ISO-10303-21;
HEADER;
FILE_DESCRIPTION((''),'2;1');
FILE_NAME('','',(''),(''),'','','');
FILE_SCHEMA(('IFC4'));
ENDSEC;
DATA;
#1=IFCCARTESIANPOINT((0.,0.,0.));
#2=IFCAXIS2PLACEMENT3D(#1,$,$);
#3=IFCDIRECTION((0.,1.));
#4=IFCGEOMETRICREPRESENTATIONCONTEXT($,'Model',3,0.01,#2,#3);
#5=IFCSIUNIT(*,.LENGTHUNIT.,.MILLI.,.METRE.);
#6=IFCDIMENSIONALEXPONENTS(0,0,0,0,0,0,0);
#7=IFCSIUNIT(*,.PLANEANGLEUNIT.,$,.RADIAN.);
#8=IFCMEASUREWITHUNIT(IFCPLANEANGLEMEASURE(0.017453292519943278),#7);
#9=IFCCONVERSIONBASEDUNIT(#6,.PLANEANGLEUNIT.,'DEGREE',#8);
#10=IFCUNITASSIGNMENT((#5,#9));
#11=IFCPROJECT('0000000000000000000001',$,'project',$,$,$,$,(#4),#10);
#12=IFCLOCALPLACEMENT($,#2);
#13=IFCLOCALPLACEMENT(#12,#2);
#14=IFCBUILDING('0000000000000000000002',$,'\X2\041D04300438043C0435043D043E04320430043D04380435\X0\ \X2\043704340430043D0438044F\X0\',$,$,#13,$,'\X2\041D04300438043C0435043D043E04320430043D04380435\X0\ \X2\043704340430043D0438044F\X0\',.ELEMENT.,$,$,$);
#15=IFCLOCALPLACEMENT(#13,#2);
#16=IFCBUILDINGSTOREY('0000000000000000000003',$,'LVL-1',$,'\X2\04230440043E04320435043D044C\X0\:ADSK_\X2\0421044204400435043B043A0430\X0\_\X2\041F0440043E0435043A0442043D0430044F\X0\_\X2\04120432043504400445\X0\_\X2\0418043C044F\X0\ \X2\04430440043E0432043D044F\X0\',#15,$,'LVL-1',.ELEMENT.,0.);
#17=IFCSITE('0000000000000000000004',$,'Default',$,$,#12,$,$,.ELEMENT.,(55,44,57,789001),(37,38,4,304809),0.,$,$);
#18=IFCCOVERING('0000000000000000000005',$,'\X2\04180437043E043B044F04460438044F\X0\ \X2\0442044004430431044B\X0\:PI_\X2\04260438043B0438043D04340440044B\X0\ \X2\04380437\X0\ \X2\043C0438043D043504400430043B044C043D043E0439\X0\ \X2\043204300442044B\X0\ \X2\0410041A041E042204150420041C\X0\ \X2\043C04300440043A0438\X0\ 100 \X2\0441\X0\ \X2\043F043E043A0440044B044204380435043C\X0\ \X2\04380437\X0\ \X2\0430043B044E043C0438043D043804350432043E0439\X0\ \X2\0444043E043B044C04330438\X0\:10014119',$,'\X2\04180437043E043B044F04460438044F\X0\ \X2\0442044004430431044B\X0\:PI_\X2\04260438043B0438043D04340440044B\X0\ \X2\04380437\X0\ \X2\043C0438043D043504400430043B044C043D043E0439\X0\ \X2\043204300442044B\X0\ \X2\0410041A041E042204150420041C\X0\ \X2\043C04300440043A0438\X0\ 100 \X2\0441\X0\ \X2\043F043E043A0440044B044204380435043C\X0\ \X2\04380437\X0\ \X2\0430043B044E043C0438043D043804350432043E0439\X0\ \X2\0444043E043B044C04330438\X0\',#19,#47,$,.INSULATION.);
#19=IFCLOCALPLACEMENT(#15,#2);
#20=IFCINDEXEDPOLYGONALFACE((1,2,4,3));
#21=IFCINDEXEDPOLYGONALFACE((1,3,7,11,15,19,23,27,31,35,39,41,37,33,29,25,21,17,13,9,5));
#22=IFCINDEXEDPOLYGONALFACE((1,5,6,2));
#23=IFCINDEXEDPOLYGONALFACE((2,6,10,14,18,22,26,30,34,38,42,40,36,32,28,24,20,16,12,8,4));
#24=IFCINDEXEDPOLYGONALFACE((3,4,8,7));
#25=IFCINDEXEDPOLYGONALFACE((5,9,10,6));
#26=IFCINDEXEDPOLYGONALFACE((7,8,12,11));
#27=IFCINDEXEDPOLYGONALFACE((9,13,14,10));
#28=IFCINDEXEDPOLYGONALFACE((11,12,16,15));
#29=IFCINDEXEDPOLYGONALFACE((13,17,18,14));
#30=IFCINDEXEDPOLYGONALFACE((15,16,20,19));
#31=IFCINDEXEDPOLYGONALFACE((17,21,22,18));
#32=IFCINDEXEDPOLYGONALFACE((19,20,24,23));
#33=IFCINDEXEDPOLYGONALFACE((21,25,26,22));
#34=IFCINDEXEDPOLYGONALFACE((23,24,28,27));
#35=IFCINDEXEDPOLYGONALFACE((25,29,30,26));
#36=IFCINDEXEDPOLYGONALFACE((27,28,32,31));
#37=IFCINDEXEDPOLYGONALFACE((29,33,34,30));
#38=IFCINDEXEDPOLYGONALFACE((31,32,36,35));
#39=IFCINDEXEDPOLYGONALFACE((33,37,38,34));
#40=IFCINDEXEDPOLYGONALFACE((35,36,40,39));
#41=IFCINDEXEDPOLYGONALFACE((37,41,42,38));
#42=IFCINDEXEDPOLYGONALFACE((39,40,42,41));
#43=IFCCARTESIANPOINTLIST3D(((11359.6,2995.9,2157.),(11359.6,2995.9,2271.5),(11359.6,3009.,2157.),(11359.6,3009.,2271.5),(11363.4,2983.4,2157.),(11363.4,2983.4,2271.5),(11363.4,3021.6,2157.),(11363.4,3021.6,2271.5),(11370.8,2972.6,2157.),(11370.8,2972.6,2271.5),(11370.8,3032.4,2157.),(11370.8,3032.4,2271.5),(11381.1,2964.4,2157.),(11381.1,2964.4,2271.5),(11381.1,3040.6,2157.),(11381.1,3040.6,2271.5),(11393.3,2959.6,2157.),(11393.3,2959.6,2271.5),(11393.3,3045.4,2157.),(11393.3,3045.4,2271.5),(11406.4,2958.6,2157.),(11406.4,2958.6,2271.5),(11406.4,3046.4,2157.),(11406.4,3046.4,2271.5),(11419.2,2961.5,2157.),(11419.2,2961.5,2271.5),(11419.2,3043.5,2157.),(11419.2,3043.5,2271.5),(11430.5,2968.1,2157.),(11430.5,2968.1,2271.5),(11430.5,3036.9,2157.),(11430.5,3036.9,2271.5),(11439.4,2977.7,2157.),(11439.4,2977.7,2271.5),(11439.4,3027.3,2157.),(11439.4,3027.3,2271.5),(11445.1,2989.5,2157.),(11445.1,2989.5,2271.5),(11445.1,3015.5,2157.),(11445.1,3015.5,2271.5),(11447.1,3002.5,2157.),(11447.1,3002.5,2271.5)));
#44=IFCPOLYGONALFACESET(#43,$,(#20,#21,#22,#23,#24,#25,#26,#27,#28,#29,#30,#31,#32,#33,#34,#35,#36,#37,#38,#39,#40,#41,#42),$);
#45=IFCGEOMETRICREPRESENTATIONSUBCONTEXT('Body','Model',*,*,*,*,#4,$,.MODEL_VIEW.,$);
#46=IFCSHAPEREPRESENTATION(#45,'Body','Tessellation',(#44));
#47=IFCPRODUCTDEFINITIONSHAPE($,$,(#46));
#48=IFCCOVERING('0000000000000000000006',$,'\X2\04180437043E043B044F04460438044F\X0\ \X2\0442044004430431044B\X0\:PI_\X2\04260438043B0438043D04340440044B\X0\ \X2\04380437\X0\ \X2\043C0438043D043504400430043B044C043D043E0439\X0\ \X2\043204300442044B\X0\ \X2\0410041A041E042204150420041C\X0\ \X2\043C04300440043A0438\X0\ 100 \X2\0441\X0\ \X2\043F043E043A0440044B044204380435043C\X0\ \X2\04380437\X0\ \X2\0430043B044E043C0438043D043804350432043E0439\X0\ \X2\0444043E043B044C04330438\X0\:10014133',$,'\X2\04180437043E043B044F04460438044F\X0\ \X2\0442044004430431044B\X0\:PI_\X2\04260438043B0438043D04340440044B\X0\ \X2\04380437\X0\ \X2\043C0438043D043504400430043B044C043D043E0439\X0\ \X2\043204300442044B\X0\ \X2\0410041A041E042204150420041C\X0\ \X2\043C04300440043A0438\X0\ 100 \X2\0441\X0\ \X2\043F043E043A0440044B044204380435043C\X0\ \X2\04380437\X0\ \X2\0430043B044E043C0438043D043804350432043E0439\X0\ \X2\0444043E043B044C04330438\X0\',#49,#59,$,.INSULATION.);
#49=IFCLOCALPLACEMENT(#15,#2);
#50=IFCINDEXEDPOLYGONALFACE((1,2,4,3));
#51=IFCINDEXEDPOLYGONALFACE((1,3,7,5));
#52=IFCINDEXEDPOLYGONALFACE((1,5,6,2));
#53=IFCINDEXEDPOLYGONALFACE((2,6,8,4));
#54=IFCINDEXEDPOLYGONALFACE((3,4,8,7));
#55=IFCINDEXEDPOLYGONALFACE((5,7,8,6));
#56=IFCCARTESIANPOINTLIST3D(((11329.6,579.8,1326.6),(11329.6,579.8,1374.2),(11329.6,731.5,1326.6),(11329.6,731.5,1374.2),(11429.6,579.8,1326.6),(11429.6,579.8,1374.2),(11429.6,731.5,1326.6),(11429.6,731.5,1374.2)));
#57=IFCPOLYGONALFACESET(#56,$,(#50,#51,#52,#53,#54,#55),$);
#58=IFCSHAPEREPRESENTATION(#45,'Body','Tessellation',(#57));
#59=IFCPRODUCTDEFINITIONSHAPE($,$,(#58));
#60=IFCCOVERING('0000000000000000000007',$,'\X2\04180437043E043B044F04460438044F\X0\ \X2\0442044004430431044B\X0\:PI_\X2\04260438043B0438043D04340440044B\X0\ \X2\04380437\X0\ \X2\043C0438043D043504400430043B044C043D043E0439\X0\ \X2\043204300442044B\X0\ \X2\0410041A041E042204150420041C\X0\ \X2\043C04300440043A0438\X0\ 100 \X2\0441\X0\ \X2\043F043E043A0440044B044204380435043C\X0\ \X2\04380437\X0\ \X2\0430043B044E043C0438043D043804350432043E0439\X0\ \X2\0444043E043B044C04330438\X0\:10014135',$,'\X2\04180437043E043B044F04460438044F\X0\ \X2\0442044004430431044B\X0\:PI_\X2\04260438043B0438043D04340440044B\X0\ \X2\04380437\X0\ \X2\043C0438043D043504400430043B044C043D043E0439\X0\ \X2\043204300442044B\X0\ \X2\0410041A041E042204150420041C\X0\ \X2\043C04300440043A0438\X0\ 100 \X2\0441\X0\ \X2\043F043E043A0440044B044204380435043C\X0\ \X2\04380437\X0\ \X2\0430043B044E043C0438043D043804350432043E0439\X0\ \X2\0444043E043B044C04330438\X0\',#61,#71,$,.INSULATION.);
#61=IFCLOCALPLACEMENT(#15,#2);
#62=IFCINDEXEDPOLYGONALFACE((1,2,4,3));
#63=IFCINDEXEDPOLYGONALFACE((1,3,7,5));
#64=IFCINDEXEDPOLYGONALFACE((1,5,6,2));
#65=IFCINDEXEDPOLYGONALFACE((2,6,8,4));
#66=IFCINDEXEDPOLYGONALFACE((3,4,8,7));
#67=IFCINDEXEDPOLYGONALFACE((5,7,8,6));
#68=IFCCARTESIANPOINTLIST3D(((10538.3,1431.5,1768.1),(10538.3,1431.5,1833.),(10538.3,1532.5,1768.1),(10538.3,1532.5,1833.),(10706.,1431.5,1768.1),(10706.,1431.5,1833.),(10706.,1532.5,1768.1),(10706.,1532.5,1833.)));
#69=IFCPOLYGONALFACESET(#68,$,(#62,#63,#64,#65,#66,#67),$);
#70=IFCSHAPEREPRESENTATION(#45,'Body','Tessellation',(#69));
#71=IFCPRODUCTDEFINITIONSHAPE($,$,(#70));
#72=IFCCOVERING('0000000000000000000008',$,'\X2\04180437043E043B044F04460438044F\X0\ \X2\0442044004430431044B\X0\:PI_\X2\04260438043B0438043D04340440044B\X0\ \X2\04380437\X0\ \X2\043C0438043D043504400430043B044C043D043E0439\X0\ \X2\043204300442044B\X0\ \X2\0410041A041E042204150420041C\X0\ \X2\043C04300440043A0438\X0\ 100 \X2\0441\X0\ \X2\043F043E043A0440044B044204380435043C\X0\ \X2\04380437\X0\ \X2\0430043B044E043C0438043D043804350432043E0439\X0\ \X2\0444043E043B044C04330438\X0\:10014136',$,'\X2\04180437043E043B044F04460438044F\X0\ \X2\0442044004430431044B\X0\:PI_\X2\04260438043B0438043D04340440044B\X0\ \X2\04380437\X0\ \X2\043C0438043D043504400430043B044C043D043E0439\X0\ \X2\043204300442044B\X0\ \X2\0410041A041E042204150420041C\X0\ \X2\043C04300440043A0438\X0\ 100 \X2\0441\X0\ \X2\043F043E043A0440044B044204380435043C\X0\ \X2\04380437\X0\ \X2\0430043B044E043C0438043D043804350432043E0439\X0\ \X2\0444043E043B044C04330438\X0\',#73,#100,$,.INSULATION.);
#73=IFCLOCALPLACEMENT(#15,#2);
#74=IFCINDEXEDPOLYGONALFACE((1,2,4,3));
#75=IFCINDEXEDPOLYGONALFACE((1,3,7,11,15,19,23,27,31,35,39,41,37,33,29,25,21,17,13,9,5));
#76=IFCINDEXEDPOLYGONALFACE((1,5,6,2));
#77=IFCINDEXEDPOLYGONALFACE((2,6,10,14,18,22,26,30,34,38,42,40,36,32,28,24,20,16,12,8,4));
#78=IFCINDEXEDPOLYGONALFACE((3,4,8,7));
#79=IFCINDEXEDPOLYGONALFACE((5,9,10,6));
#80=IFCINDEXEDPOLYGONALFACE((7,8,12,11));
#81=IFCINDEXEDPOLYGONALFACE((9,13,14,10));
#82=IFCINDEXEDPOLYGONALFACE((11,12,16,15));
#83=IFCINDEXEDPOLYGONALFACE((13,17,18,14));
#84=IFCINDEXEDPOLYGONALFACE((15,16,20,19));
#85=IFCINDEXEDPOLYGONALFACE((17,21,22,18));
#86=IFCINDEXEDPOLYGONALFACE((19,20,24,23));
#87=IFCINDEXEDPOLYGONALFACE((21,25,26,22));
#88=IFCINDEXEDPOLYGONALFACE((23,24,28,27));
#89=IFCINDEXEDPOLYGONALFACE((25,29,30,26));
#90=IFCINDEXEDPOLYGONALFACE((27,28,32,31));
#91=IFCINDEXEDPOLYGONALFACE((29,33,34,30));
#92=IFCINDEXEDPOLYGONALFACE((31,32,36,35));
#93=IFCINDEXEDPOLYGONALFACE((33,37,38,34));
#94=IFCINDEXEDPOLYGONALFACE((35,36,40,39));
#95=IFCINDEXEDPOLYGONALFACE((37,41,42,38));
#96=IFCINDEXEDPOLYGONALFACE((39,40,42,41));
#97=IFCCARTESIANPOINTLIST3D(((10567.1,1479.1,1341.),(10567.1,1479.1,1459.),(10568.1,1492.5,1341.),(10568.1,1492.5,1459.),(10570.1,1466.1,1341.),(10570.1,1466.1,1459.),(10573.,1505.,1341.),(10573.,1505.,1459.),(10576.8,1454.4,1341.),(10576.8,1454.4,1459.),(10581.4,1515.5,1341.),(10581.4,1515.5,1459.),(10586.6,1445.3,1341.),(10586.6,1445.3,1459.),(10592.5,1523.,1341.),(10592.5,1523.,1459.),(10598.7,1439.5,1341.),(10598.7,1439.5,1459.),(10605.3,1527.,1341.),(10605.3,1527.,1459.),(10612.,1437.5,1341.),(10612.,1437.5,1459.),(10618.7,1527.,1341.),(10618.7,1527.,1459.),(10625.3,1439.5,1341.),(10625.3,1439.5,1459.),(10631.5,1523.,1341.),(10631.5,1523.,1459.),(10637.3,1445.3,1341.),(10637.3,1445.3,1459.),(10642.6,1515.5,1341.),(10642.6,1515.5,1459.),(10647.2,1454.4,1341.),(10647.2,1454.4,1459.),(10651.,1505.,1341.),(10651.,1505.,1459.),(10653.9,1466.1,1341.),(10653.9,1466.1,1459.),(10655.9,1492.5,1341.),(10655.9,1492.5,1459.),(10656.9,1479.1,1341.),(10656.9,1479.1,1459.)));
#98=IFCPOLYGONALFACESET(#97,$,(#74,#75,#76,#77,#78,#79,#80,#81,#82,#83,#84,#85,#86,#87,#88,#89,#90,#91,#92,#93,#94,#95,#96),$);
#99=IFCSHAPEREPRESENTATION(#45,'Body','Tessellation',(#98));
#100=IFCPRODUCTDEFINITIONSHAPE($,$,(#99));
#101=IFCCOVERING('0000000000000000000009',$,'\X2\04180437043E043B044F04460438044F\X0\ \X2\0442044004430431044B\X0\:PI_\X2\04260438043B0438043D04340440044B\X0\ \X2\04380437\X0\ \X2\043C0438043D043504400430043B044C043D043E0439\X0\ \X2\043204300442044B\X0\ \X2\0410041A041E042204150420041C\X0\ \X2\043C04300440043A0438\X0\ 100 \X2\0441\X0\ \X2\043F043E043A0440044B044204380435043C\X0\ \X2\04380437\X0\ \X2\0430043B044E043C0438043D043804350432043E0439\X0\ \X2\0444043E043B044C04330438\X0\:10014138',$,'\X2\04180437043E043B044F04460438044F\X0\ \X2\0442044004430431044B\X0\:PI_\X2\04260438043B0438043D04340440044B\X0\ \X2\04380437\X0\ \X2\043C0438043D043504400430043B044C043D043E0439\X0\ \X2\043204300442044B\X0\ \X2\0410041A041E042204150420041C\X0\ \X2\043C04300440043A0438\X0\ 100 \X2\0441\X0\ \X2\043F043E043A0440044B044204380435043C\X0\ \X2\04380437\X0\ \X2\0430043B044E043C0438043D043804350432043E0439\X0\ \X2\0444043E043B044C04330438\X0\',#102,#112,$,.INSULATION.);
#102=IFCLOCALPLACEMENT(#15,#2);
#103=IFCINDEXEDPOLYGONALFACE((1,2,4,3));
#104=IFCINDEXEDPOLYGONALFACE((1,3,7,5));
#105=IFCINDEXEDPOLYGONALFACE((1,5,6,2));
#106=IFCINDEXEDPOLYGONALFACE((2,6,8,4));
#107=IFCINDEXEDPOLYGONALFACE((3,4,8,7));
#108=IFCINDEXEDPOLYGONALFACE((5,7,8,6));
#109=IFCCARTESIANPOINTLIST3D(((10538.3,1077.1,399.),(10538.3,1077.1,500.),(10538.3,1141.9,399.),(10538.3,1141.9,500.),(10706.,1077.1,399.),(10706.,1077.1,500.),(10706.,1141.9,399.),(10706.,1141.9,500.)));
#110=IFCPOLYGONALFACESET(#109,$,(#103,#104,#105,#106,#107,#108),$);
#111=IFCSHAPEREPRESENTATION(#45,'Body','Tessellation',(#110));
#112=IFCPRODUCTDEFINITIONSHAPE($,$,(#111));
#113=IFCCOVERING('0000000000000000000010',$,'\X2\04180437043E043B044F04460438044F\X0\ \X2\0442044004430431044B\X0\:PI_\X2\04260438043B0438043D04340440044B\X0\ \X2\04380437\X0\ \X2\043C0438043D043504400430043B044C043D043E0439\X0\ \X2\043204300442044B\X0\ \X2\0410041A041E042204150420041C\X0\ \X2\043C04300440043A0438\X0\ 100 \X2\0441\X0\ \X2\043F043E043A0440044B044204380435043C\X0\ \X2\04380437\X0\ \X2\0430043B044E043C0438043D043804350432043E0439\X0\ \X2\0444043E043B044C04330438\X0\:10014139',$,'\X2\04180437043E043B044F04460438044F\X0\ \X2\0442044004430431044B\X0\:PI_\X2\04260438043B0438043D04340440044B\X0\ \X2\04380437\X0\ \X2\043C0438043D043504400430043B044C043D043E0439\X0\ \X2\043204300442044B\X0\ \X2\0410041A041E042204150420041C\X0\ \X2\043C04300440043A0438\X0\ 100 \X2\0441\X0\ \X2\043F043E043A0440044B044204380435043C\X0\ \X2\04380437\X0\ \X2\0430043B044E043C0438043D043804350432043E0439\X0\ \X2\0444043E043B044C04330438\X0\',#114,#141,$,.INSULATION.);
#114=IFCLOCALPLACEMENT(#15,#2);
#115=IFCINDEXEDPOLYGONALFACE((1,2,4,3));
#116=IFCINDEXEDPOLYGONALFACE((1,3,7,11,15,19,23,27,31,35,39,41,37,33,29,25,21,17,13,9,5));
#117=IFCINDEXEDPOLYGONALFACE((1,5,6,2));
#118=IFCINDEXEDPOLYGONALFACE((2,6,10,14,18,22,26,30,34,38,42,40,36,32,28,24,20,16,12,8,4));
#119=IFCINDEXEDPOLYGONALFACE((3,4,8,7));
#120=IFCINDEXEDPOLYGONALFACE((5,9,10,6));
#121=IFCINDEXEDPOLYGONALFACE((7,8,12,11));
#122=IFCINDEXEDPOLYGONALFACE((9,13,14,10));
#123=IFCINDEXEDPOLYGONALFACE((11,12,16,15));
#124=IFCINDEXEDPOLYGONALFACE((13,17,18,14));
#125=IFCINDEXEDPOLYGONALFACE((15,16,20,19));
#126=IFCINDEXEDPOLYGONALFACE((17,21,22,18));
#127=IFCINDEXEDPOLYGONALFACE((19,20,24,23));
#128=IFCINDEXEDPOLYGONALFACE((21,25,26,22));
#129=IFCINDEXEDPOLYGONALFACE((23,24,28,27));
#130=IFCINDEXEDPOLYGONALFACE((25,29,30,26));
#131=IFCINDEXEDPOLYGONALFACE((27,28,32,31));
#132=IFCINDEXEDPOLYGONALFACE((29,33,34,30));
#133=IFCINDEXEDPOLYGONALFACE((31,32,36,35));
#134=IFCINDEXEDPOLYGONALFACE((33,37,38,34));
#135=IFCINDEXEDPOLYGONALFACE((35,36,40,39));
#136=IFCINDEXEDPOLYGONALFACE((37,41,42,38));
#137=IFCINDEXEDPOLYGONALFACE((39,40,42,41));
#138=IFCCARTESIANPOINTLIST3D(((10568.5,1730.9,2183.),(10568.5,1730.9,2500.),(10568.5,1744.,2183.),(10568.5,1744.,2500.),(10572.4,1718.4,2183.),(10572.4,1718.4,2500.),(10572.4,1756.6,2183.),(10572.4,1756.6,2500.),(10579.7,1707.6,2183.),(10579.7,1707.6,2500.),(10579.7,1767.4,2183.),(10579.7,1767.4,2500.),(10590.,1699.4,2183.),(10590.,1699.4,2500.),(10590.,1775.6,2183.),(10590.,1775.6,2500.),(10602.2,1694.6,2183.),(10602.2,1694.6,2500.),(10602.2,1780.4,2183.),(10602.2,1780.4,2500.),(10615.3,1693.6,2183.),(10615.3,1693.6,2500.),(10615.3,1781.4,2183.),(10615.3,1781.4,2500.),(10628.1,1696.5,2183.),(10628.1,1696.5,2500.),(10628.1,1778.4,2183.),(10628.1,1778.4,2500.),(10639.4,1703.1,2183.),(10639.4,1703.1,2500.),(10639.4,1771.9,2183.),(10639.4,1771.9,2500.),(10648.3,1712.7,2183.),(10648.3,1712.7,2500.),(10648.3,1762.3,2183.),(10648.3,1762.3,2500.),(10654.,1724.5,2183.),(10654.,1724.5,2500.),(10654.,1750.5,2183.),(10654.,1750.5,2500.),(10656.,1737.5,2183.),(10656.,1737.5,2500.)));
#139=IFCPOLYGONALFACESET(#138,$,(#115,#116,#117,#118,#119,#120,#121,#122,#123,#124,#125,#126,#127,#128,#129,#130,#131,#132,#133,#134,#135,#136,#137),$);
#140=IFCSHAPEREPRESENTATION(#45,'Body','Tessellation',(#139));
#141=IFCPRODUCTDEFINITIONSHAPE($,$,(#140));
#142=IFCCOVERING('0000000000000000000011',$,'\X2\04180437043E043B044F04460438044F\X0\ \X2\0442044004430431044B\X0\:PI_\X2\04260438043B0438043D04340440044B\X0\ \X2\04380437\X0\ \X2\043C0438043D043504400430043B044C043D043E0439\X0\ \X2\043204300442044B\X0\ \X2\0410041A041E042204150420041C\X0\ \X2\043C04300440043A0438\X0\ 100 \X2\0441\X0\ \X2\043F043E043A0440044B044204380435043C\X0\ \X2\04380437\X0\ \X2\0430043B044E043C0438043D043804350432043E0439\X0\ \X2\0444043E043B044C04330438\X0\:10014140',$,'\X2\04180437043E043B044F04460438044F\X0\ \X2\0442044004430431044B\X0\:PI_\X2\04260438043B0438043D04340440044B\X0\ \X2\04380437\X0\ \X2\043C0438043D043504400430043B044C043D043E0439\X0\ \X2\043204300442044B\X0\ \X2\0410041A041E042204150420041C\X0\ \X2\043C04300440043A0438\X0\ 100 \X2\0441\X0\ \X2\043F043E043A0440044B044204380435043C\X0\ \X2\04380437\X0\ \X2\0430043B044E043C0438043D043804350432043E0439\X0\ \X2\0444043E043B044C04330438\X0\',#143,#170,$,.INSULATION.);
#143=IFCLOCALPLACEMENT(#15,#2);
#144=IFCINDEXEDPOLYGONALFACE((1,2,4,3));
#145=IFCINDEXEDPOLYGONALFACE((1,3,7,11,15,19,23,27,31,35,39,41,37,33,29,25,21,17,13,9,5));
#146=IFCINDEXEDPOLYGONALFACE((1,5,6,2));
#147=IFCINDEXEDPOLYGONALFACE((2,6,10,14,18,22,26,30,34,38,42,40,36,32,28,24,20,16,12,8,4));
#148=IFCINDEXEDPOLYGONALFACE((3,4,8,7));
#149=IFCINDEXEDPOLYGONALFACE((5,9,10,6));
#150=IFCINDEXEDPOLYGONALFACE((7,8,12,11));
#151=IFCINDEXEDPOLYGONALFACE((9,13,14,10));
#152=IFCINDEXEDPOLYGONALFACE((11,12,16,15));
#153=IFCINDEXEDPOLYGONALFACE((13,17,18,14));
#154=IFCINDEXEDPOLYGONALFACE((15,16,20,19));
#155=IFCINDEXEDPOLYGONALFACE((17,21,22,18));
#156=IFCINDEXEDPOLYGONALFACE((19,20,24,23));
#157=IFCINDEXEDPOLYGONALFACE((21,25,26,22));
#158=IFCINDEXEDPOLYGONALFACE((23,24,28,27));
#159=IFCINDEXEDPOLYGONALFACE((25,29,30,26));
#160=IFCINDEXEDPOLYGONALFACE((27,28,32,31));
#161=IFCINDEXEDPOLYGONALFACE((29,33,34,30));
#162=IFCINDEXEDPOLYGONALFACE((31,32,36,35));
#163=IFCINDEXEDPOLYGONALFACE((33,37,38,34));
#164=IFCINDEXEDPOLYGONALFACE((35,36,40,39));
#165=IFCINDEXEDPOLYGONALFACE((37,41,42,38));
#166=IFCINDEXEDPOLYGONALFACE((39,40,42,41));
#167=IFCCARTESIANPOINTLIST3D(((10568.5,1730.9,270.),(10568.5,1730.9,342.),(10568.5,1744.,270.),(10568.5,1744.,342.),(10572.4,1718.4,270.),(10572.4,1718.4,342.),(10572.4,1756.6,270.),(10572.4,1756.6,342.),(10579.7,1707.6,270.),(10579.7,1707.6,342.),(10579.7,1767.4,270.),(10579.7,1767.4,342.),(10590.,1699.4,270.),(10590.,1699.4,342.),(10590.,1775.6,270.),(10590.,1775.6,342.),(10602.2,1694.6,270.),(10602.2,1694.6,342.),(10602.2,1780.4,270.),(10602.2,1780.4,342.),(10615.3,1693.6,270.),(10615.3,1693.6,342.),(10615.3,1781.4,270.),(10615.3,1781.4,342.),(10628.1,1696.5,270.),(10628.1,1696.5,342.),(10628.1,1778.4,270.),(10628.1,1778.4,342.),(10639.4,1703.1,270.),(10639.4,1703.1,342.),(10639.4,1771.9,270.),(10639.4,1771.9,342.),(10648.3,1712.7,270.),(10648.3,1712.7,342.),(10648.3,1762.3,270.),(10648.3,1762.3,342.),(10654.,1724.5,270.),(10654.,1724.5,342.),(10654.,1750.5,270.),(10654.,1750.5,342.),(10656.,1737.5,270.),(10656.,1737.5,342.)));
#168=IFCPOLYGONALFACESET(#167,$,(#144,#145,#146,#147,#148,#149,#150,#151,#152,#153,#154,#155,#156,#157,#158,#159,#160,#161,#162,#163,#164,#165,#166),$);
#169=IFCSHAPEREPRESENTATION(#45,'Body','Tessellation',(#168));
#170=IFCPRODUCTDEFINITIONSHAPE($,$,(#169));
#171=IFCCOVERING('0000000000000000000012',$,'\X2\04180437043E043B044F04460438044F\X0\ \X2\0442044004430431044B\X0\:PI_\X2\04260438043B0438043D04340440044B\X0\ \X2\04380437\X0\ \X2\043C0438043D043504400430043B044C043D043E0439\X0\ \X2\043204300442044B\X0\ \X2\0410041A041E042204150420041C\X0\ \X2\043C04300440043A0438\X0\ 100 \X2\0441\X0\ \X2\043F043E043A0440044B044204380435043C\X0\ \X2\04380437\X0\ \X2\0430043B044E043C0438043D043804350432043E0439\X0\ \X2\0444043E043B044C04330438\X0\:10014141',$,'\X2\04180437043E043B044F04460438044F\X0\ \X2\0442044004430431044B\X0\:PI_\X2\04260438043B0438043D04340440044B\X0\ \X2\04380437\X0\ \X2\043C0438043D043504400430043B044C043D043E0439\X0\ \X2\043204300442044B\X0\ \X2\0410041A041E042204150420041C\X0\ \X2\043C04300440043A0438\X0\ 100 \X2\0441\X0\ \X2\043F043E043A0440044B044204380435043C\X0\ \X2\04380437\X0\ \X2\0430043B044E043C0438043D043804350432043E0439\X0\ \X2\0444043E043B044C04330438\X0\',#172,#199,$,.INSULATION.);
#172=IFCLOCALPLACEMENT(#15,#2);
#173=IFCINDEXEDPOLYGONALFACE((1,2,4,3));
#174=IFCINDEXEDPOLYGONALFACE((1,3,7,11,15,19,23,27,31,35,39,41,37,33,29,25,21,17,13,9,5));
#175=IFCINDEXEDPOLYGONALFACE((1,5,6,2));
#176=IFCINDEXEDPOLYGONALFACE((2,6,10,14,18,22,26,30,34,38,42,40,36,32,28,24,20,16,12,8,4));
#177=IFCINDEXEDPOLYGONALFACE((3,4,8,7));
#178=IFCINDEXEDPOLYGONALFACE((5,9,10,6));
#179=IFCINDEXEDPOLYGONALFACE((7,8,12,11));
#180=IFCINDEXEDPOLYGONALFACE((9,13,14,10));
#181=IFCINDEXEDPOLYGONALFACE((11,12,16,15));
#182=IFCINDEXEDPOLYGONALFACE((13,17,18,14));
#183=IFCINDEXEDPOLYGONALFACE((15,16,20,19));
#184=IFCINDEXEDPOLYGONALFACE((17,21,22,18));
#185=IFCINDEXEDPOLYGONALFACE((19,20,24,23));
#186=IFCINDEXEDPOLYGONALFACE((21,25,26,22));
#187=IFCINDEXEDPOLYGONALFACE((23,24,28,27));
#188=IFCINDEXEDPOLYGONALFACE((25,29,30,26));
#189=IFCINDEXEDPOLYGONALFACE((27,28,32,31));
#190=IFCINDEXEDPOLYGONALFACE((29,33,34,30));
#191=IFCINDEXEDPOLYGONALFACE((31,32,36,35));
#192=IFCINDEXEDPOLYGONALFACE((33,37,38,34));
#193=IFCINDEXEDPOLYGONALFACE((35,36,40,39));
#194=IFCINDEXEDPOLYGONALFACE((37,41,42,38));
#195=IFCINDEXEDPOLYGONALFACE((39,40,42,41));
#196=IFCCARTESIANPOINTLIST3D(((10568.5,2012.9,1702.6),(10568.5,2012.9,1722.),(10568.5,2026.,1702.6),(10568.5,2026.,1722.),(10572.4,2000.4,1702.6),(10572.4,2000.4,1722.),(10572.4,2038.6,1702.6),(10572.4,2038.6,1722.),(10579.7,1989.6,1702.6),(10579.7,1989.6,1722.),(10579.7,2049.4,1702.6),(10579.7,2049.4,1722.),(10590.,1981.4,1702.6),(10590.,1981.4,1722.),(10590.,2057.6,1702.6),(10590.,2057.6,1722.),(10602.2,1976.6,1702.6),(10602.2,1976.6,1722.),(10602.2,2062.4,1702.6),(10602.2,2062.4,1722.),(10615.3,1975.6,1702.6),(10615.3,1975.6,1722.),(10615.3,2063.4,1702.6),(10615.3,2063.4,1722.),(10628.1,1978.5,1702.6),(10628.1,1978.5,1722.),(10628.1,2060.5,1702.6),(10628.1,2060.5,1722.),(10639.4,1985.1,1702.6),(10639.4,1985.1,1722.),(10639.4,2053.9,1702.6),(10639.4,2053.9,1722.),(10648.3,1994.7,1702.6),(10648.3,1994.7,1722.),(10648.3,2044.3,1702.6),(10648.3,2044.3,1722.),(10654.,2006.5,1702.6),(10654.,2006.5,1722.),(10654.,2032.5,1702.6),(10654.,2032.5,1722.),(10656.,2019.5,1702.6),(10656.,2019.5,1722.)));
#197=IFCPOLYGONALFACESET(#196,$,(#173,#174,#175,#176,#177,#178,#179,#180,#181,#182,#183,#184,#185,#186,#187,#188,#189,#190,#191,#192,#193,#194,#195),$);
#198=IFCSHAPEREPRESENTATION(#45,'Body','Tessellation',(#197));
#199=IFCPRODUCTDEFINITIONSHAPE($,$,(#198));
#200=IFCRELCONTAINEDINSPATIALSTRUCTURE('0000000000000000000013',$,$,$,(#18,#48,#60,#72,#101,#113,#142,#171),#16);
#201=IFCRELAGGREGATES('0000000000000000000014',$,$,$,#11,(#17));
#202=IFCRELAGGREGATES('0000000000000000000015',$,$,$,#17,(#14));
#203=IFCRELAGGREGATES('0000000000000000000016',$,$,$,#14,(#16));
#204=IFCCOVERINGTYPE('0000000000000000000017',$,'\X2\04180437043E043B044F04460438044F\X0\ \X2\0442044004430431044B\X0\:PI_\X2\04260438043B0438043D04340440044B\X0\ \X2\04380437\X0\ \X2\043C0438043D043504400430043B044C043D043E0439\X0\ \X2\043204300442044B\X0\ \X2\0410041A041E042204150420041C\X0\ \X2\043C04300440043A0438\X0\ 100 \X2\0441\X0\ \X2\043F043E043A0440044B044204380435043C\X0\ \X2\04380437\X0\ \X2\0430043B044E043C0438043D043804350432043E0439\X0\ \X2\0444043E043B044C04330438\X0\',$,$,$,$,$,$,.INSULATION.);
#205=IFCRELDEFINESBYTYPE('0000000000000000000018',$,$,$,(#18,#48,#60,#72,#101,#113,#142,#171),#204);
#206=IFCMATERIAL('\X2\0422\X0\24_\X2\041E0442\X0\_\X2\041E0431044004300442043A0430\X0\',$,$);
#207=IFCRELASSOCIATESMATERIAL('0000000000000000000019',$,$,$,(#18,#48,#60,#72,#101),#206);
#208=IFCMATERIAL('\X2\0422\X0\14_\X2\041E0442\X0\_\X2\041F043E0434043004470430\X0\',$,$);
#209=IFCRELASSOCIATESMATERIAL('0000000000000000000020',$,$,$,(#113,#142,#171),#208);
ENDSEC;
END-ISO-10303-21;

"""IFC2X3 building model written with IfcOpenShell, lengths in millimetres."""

from ifc_helpers import new_model, entity, si_unit, converted_unit, direction, frame, frame_2d, origin, origin_2d_with_axis, place, context, subcontext, project, spatial, rectangle, circle, extrude, material, type_object, element, save


model = new_model("IFC2X3")

# Units and contexts
model_context = context("Model", 3, precision=0.01, world=origin(), true_north=direction((0.0, 1.0)))
body_context = subcontext(model_context, "Body", "Model", "MODEL_VIEW")
ifc_project = project(units=[si_unit("LENGTHUNIT", "METRE", prefix="MILLI"), converted_unit("PLANEANGLEUNIT", "DEGREE", entity("IfcPlaneAngleMeasure", 0.017453292519943278), si_unit("PLANEANGLEUNIT", "RADIAN"), dimensions=[0, 0, 0, 0, 0, 0, 0])], contexts=[model_context])

# Site, building, storey
site_placement = place(None, origin())
site = spatial("IfcSite", under=ifc_project, at=site_placement, Name="Default", CompositionType="ELEMENT", RefLatitude=(55, 44, 57, 789001), RefLongitude=(37, 38, 4, 304809), RefElevation=0.0)
building_placement = place(site_placement, origin())
building = spatial("IfcBuilding", under=site, at=building_placement, Name="Наименование здания", LongName="Наименование здания", CompositionType="ELEMENT")
storey_placement = place(building_placement, origin())
storey = spatial("IfcBuildingStorey", under=building, at=storey_placement, Name="LVL-1", ObjectType="Уровень:ADSK_Стрелка_Проектная_Вверх_Имя уровня", LongName="LVL-1", CompositionType="ELEMENT", Elevation=0.0)

# Coverings
covering_type = type_object("IfcCoveringType", Name="Изоляция трубы:PI_Цилиндры из минеральной ваты АКОТЕРМ марки 100 с покрытием из алюминиевой фольги", PredefinedType="INSULATION")
ifc_material_1 = material(Name="Т24_От_Обратка")
covering_1_placement = place(storey_placement, origin())
element("IfcCovering", 1, at=covering_1_placement, inside=storey, type_object=covering_type, material=ifc_material_1, Name="Изоляция трубы:PI_Цилиндры из минеральной ваты АКОТЕРМ марки 100 с покрытием из алюминиевой фольги:10014119", ObjectType="Изоляция трубы:PI_Цилиндры из минеральной ваты АКОТЕРМ марки 100 с покрытием из алюминиевой фольги", PredefinedType="INSULATION", context=body_context, shape_type="SweptSolid", body=[
    extrude(circle(Radius=44.0, at=origin_2d_with_axis()), frame((11403.1, 3002.5, 2157.0)), (0.0, 0.0, 1.0), 114.5),
])
covering_2_placement = place(storey_placement, origin())
element("IfcCovering", 2, at=covering_2_placement, inside=storey, type_object=covering_type, material=ifc_material_1, Name="Изоляция трубы:PI_Цилиндры из минеральной ваты АКОТЕРМ марки 100 с покрытием из алюминиевой фольги:10014133", ObjectType="Изоляция трубы:PI_Цилиндры из минеральной ваты АКОТЕРМ марки 100 с покрытием из алюминиевой фольги", PredefinedType="INSULATION", context=body_context, shape_type="SweptSolid", body=[
    extrude(rectangle(XDim=100.0, YDim=151.7, at=frame_2d((0.0, 0.0), x_axis=(1.0, 0.0))), frame((11379.6, 655.6, 1326.6)), (0.0, 0.0, 1.0), 47.7),
])
covering_3_placement = place(storey_placement, origin())
element("IfcCovering", 3, at=covering_3_placement, inside=storey, type_object=covering_type, material=ifc_material_1, Name="Изоляция трубы:PI_Цилиндры из минеральной ваты АКОТЕРМ марки 100 с покрытием из алюминиевой фольги:10014135", ObjectType="Изоляция трубы:PI_Цилиндры из минеральной ваты АКОТЕРМ марки 100 с покрытием из алюминиевой фольги", PredefinedType="INSULATION", context=body_context, shape_type="SweptSolid", body=[
    extrude(rectangle(XDim=167.7, YDim=101.0, at=origin_2d_with_axis()), frame((10622.1, 1482.0, 1768.1)), (0.0, 0.0, 1.0), 64.9),
])
covering_4_placement = place(storey_placement, origin())
element("IfcCovering", 4, at=covering_4_placement, inside=storey, type_object=covering_type, material=ifc_material_1, Name="Изоляция трубы:PI_Цилиндры из минеральной ваты АКОТЕРМ марки 100 с покрытием из алюминиевой фольги:10014136", ObjectType="Изоляция трубы:PI_Цилиндры из минеральной ваты АКОТЕРМ марки 100 с покрытием из алюминиевой фольги", PredefinedType="INSULATION", context=body_context, shape_type="SweptSolid", body=[
    extrude(circle(Radius=45.0, at=frame_2d((0.0, 0.0), x_axis=(1.0, 0.0))), frame((10612.0, 1482.5, 1341.0), z_axis=(0.0, 0.0, 1.0), x_axis=(0.0, -1.0, 0.0)), (0.0, 0.0, 1.0), 118.0),
])
covering_5_placement = place(storey_placement, origin())
element("IfcCovering", 5, at=covering_5_placement, inside=storey, type_object=covering_type, material=ifc_material_1, Name="Изоляция трубы:PI_Цилиндры из минеральной ваты АКОТЕРМ марки 100 с покрытием из алюминиевой фольги:10014138", ObjectType="Изоляция трубы:PI_Цилиндры из минеральной ваты АКОТЕРМ марки 100 с покрытием из алюминиевой фольги", PredefinedType="INSULATION", context=body_context, shape_type="SweptSolid", body=[
    extrude(rectangle(XDim=167.7, YDim=64.9, at=origin_2d_with_axis()), frame((10622.1, 1109.5, 399.0)), (0.0, 0.0, 1.0), 101.0),
])
ifc_material_2 = material(Name="Т14_От_Подача")
covering_6_placement = place(storey_placement, origin())
element("IfcCovering", 6, at=covering_6_placement, inside=storey, type_object=covering_type, material=ifc_material_2, Name="Изоляция трубы:PI_Цилиндры из минеральной ваты АКОТЕРМ марки 100 с покрытием из алюминиевой фольги:10014139", ObjectType="Изоляция трубы:PI_Цилиндры из минеральной ваты АКОТЕРМ марки 100 с покрытием из алюминиевой фольги", PredefinedType="INSULATION", context=body_context, shape_type="SweptSolid", body=[
    extrude(circle(Radius=44.0, at=origin_2d_with_axis()), frame((10612.0, 1737.5, 2183.0)), (0.0, 0.0, 1.0), 317.0),
])
covering_7_placement = place(storey_placement, origin())
element("IfcCovering", 7, at=covering_7_placement, inside=storey, type_object=covering_type, material=ifc_material_2, Name="Изоляция трубы:PI_Цилиндры из минеральной ваты АКОТЕРМ марки 100 с покрытием из алюминиевой фольги:10014140", ObjectType="Изоляция трубы:PI_Цилиндры из минеральной ваты АКОТЕРМ марки 100 с покрытием из алюминиевой фольги", PredefinedType="INSULATION", context=body_context, shape_type="SweptSolid", body=[
    extrude(circle(Radius=44.0, at=frame_2d((0.0, 0.0), x_axis=(1.0, 0.0))), frame((10612.0, 1737.5, 270.0)), (0.0, 0.0, 1.0), 72.0),
])
covering_8_placement = place(storey_placement, origin())
element("IfcCovering", 8, at=covering_8_placement, inside=storey, type_object=covering_type, material=ifc_material_2, Name="Изоляция трубы:PI_Цилиндры из минеральной ваты АКОТЕРМ марки 100 с покрытием из алюминиевой фольги:10014141", ObjectType="Изоляция трубы:PI_Цилиндры из минеральной ваты АКОТЕРМ марки 100 с покрытием из алюминиевой фольги", PredefinedType="INSULATION", context=body_context, shape_type="SweptSolid", body=[
    extrude(circle(Radius=44.0, at=frame_2d((0.0, 0.0), x_axis=(1.0, 0.0))), frame((10612.0, 2019.5, 1702.6)), (0.0, 0.0, 1.0), 19.4),
])

save(model, "model.ifc")
